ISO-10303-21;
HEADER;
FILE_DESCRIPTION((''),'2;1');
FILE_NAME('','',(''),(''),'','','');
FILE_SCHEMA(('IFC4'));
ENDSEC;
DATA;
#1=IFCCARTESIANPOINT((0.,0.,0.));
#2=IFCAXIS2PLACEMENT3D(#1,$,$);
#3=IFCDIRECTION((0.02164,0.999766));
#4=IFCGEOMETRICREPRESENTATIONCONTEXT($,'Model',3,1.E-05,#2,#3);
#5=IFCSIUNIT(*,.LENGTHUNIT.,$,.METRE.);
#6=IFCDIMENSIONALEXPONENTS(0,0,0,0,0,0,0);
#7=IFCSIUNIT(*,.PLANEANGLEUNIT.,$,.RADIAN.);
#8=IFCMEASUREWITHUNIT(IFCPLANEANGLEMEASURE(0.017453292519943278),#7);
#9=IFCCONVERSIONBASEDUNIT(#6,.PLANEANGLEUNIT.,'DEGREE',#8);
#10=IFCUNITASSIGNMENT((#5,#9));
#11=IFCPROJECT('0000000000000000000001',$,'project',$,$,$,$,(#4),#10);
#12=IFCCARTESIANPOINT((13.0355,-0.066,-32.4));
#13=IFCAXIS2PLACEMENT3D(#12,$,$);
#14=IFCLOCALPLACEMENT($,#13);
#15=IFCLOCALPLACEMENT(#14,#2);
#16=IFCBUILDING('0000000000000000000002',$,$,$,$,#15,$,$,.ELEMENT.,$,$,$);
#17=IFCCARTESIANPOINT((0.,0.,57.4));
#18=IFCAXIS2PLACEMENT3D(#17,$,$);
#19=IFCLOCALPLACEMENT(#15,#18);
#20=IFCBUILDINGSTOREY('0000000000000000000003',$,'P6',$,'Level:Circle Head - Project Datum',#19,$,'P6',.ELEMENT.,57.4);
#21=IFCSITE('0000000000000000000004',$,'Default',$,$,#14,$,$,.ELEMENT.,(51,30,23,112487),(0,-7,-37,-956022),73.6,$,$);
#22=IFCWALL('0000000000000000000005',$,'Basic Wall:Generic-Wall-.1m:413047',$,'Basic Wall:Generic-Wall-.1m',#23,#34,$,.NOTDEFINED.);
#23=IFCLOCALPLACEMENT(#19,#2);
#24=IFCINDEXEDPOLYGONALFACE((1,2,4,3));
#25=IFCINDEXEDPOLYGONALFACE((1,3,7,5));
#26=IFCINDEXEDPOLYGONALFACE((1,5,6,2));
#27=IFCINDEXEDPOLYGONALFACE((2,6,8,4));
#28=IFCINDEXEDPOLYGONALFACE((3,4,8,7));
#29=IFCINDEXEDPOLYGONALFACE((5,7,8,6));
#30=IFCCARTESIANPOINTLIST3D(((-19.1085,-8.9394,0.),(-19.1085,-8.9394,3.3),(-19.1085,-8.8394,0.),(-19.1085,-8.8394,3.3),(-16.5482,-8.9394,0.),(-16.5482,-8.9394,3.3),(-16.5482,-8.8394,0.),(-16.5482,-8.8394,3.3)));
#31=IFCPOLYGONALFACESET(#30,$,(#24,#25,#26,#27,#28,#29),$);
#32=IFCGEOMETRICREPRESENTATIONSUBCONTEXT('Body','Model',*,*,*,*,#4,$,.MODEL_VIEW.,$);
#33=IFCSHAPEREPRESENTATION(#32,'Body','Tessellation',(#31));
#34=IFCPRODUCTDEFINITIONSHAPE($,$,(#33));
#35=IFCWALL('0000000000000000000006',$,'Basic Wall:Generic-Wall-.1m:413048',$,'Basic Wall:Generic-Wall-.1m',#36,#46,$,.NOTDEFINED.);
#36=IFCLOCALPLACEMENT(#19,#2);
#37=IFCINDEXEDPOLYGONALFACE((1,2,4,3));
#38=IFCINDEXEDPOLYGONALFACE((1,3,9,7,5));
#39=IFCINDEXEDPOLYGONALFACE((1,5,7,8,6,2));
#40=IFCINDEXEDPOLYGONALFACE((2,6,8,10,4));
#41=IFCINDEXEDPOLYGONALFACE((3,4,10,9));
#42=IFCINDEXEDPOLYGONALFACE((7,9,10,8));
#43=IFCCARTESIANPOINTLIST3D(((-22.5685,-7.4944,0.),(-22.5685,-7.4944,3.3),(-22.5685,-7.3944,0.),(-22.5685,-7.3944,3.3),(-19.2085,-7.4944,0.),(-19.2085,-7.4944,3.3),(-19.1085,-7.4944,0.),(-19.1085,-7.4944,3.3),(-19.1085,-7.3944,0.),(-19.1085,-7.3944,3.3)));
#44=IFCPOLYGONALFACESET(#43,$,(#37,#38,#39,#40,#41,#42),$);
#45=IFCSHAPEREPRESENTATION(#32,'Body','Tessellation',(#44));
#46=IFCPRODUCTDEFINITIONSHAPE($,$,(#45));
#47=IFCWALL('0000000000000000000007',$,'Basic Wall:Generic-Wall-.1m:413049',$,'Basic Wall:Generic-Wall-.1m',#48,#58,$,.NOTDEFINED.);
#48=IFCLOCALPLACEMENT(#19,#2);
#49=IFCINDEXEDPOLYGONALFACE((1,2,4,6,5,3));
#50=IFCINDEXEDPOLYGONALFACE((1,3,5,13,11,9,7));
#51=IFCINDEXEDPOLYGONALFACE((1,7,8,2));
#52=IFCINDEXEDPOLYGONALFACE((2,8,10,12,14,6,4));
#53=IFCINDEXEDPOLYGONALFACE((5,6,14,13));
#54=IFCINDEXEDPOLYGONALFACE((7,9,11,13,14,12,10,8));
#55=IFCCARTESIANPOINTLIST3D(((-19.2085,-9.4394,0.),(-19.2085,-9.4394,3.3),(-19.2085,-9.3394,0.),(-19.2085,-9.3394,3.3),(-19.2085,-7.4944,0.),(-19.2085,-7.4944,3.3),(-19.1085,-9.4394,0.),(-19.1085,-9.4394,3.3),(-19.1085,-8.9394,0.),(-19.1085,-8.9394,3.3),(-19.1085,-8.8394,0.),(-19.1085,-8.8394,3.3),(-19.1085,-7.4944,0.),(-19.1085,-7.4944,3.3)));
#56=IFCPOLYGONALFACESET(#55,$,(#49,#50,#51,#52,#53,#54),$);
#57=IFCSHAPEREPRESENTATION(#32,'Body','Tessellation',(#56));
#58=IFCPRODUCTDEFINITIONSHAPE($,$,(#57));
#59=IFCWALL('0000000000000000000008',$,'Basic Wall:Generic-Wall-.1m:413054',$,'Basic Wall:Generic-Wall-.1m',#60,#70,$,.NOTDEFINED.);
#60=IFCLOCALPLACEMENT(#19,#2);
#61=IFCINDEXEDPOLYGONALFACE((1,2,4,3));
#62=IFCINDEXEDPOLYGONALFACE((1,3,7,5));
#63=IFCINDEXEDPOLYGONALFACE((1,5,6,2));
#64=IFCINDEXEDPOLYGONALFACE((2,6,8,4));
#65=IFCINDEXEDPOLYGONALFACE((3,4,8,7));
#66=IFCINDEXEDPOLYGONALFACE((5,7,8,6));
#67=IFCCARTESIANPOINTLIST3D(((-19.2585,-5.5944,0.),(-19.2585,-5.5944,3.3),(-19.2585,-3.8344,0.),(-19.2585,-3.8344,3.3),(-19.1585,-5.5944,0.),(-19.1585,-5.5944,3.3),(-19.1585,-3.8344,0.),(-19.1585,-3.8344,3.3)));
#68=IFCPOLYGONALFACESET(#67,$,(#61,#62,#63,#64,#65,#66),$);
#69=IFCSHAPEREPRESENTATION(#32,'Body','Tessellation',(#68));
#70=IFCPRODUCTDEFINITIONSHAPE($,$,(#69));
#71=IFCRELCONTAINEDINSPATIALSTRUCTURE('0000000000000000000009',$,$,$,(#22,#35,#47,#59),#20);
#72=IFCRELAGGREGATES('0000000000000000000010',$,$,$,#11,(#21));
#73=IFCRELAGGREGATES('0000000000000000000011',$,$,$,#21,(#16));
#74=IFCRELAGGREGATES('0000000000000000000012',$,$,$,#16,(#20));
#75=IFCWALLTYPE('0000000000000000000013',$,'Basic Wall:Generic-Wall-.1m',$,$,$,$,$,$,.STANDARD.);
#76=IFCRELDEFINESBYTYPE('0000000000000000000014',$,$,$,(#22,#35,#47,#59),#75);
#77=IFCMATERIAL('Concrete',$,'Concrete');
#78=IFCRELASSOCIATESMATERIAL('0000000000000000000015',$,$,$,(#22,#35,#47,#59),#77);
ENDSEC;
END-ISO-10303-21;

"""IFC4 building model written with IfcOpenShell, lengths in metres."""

from ifc_helpers import new_model, entity, si_unit, converted_unit, direction, frame, origin, place, context, subcontext, project, spatial, indexed_curve, outline, extrude, material, type_object, element, save


model = new_model("IFC4")

# Units and contexts
model_context = context("Model", 3, precision=1e-05, world=origin(), true_north=direction((0.02164, 0.999766)))
body_context = subcontext(model_context, "Body", "Model", "MODEL_VIEW")
ifc_project = project(units=[si_unit("LENGTHUNIT", "METRE"), converted_unit("PLANEANGLEUNIT", "DEGREE", entity("IfcPlaneAngleMeasure", 0.017453292519943278), si_unit("PLANEANGLEUNIT", "RADIAN"), dimensions=[0, 0, 0, 0, 0, 0, 0])], contexts=[model_context])

# Site, building, storey
site_placement = place(None, frame((13.0355, -0.066, -32.4)))
site = spatial("IfcSite", under=ifc_project, at=site_placement, Name="Default", CompositionType="ELEMENT", RefLatitude=(51, 30, 23, 112487), RefLongitude=(0, -7, -37, -956022), RefElevation=73.6)
building_placement = place(site_placement, origin())
building = spatial("IfcBuilding", under=site, at=building_placement, CompositionType="ELEMENT")
storey_placement = place(building_placement, frame((0.0, 0.0, 57.4)))
storey = spatial("IfcBuildingStorey", under=building, at=storey_placement, Name="P6", ObjectType="Level:Circle Head - Project Datum", LongName="P6", CompositionType="ELEMENT", Elevation=57.4)

# Shared definitions
ifc_material = material(Name="Concrete", Category="Concrete")

# Walls
wall_type = type_object("IfcWallType", Name="Basic Wall:Generic-Wall-.1m", PredefinedType="STANDARD")
wall_1_placement = place(storey_placement, frame((-19.1085, -8.8894, 0.0)))
element("IfcWall", 1, at=wall_1_placement, inside=storey, type_object=wall_type, material=ifc_material, Name="Basic Wall:Generic-Wall-.1m:413047", ObjectType="Basic Wall:Generic-Wall-.1m", PredefinedType="NOTDEFINED", context=body_context, shape_type="SweptSolid", body=[
    extrude(outline(indexed_curve([(2.5602, -0.05), (2.5602, 0.05), (0.0, 0.05), (0.0, -0.05), (2.5602, -0.05)], self_intersect=False)), origin(), (0.0, 0.0, 1.0), 3.3),
])
wall_2_placement = place(storey_placement, frame((-22.5685, -7.4444, 0.0)))
element("IfcWall", 2, at=wall_2_placement, inside=storey, type_object=wall_type, material=ifc_material, Name="Basic Wall:Generic-Wall-.1m:413048", ObjectType="Basic Wall:Generic-Wall-.1m", PredefinedType="NOTDEFINED", context=body_context, shape_type="SweptSolid", body=[
    extrude(outline(indexed_curve([(3.46, -0.05), (3.46, 0.05), (0.0, 0.05), (0.0, -0.05), (3.36, -0.05), (3.46, -0.05)], self_intersect=False)), origin(), (0.0, 0.0, 1.0), 3.3),
])
wall_3_placement = place(storey_placement, frame((-19.1585, -7.4944, 0.0), z_axis=(0.0, 0.0, 1.0), x_axis=(0.0, -1.0, 0.0)))
element("IfcWall", 3, at=wall_3_placement, inside=storey, type_object=wall_type, material=ifc_material, Name="Basic Wall:Generic-Wall-.1m:413049", ObjectType="Basic Wall:Generic-Wall-.1m", PredefinedType="NOTDEFINED", context=body_context, shape_type="SweptSolid", body=[
    extrude(outline(indexed_curve([(1.945, -0.05), (1.945, 0.05), (1.445, 0.05), (1.345, 0.05), (0.0, 0.05), (0.0, -0.05), (1.845, -0.05), (1.945, -0.05)], self_intersect=False)), origin(), (0.0, 0.0, 1.0), 3.3),
])
wall_4_placement = place(storey_placement, frame((-19.2085, -5.5944, 0.0), z_axis=(0.0, 0.0, 1.0), x_axis=(0.0, 1.0, 0.0)))
element("IfcWall", 4, at=wall_4_placement, inside=storey, type_object=wall_type, material=ifc_material, Name="Basic Wall:Generic-Wall-.1m:413054", ObjectType="Basic Wall:Generic-Wall-.1m", PredefinedType="NOTDEFINED", context=body_context, shape_type="SweptSolid", body=[
    extrude(outline(indexed_curve([(1.76, -0.05), (1.76, 0.05), (0.0, 0.05), (0.0, -0.05), (1.76, -0.05)], self_intersect=False)), origin(), (0.0, 0.0, 1.0), 3.3),
])

save(model, "model.ifc")
